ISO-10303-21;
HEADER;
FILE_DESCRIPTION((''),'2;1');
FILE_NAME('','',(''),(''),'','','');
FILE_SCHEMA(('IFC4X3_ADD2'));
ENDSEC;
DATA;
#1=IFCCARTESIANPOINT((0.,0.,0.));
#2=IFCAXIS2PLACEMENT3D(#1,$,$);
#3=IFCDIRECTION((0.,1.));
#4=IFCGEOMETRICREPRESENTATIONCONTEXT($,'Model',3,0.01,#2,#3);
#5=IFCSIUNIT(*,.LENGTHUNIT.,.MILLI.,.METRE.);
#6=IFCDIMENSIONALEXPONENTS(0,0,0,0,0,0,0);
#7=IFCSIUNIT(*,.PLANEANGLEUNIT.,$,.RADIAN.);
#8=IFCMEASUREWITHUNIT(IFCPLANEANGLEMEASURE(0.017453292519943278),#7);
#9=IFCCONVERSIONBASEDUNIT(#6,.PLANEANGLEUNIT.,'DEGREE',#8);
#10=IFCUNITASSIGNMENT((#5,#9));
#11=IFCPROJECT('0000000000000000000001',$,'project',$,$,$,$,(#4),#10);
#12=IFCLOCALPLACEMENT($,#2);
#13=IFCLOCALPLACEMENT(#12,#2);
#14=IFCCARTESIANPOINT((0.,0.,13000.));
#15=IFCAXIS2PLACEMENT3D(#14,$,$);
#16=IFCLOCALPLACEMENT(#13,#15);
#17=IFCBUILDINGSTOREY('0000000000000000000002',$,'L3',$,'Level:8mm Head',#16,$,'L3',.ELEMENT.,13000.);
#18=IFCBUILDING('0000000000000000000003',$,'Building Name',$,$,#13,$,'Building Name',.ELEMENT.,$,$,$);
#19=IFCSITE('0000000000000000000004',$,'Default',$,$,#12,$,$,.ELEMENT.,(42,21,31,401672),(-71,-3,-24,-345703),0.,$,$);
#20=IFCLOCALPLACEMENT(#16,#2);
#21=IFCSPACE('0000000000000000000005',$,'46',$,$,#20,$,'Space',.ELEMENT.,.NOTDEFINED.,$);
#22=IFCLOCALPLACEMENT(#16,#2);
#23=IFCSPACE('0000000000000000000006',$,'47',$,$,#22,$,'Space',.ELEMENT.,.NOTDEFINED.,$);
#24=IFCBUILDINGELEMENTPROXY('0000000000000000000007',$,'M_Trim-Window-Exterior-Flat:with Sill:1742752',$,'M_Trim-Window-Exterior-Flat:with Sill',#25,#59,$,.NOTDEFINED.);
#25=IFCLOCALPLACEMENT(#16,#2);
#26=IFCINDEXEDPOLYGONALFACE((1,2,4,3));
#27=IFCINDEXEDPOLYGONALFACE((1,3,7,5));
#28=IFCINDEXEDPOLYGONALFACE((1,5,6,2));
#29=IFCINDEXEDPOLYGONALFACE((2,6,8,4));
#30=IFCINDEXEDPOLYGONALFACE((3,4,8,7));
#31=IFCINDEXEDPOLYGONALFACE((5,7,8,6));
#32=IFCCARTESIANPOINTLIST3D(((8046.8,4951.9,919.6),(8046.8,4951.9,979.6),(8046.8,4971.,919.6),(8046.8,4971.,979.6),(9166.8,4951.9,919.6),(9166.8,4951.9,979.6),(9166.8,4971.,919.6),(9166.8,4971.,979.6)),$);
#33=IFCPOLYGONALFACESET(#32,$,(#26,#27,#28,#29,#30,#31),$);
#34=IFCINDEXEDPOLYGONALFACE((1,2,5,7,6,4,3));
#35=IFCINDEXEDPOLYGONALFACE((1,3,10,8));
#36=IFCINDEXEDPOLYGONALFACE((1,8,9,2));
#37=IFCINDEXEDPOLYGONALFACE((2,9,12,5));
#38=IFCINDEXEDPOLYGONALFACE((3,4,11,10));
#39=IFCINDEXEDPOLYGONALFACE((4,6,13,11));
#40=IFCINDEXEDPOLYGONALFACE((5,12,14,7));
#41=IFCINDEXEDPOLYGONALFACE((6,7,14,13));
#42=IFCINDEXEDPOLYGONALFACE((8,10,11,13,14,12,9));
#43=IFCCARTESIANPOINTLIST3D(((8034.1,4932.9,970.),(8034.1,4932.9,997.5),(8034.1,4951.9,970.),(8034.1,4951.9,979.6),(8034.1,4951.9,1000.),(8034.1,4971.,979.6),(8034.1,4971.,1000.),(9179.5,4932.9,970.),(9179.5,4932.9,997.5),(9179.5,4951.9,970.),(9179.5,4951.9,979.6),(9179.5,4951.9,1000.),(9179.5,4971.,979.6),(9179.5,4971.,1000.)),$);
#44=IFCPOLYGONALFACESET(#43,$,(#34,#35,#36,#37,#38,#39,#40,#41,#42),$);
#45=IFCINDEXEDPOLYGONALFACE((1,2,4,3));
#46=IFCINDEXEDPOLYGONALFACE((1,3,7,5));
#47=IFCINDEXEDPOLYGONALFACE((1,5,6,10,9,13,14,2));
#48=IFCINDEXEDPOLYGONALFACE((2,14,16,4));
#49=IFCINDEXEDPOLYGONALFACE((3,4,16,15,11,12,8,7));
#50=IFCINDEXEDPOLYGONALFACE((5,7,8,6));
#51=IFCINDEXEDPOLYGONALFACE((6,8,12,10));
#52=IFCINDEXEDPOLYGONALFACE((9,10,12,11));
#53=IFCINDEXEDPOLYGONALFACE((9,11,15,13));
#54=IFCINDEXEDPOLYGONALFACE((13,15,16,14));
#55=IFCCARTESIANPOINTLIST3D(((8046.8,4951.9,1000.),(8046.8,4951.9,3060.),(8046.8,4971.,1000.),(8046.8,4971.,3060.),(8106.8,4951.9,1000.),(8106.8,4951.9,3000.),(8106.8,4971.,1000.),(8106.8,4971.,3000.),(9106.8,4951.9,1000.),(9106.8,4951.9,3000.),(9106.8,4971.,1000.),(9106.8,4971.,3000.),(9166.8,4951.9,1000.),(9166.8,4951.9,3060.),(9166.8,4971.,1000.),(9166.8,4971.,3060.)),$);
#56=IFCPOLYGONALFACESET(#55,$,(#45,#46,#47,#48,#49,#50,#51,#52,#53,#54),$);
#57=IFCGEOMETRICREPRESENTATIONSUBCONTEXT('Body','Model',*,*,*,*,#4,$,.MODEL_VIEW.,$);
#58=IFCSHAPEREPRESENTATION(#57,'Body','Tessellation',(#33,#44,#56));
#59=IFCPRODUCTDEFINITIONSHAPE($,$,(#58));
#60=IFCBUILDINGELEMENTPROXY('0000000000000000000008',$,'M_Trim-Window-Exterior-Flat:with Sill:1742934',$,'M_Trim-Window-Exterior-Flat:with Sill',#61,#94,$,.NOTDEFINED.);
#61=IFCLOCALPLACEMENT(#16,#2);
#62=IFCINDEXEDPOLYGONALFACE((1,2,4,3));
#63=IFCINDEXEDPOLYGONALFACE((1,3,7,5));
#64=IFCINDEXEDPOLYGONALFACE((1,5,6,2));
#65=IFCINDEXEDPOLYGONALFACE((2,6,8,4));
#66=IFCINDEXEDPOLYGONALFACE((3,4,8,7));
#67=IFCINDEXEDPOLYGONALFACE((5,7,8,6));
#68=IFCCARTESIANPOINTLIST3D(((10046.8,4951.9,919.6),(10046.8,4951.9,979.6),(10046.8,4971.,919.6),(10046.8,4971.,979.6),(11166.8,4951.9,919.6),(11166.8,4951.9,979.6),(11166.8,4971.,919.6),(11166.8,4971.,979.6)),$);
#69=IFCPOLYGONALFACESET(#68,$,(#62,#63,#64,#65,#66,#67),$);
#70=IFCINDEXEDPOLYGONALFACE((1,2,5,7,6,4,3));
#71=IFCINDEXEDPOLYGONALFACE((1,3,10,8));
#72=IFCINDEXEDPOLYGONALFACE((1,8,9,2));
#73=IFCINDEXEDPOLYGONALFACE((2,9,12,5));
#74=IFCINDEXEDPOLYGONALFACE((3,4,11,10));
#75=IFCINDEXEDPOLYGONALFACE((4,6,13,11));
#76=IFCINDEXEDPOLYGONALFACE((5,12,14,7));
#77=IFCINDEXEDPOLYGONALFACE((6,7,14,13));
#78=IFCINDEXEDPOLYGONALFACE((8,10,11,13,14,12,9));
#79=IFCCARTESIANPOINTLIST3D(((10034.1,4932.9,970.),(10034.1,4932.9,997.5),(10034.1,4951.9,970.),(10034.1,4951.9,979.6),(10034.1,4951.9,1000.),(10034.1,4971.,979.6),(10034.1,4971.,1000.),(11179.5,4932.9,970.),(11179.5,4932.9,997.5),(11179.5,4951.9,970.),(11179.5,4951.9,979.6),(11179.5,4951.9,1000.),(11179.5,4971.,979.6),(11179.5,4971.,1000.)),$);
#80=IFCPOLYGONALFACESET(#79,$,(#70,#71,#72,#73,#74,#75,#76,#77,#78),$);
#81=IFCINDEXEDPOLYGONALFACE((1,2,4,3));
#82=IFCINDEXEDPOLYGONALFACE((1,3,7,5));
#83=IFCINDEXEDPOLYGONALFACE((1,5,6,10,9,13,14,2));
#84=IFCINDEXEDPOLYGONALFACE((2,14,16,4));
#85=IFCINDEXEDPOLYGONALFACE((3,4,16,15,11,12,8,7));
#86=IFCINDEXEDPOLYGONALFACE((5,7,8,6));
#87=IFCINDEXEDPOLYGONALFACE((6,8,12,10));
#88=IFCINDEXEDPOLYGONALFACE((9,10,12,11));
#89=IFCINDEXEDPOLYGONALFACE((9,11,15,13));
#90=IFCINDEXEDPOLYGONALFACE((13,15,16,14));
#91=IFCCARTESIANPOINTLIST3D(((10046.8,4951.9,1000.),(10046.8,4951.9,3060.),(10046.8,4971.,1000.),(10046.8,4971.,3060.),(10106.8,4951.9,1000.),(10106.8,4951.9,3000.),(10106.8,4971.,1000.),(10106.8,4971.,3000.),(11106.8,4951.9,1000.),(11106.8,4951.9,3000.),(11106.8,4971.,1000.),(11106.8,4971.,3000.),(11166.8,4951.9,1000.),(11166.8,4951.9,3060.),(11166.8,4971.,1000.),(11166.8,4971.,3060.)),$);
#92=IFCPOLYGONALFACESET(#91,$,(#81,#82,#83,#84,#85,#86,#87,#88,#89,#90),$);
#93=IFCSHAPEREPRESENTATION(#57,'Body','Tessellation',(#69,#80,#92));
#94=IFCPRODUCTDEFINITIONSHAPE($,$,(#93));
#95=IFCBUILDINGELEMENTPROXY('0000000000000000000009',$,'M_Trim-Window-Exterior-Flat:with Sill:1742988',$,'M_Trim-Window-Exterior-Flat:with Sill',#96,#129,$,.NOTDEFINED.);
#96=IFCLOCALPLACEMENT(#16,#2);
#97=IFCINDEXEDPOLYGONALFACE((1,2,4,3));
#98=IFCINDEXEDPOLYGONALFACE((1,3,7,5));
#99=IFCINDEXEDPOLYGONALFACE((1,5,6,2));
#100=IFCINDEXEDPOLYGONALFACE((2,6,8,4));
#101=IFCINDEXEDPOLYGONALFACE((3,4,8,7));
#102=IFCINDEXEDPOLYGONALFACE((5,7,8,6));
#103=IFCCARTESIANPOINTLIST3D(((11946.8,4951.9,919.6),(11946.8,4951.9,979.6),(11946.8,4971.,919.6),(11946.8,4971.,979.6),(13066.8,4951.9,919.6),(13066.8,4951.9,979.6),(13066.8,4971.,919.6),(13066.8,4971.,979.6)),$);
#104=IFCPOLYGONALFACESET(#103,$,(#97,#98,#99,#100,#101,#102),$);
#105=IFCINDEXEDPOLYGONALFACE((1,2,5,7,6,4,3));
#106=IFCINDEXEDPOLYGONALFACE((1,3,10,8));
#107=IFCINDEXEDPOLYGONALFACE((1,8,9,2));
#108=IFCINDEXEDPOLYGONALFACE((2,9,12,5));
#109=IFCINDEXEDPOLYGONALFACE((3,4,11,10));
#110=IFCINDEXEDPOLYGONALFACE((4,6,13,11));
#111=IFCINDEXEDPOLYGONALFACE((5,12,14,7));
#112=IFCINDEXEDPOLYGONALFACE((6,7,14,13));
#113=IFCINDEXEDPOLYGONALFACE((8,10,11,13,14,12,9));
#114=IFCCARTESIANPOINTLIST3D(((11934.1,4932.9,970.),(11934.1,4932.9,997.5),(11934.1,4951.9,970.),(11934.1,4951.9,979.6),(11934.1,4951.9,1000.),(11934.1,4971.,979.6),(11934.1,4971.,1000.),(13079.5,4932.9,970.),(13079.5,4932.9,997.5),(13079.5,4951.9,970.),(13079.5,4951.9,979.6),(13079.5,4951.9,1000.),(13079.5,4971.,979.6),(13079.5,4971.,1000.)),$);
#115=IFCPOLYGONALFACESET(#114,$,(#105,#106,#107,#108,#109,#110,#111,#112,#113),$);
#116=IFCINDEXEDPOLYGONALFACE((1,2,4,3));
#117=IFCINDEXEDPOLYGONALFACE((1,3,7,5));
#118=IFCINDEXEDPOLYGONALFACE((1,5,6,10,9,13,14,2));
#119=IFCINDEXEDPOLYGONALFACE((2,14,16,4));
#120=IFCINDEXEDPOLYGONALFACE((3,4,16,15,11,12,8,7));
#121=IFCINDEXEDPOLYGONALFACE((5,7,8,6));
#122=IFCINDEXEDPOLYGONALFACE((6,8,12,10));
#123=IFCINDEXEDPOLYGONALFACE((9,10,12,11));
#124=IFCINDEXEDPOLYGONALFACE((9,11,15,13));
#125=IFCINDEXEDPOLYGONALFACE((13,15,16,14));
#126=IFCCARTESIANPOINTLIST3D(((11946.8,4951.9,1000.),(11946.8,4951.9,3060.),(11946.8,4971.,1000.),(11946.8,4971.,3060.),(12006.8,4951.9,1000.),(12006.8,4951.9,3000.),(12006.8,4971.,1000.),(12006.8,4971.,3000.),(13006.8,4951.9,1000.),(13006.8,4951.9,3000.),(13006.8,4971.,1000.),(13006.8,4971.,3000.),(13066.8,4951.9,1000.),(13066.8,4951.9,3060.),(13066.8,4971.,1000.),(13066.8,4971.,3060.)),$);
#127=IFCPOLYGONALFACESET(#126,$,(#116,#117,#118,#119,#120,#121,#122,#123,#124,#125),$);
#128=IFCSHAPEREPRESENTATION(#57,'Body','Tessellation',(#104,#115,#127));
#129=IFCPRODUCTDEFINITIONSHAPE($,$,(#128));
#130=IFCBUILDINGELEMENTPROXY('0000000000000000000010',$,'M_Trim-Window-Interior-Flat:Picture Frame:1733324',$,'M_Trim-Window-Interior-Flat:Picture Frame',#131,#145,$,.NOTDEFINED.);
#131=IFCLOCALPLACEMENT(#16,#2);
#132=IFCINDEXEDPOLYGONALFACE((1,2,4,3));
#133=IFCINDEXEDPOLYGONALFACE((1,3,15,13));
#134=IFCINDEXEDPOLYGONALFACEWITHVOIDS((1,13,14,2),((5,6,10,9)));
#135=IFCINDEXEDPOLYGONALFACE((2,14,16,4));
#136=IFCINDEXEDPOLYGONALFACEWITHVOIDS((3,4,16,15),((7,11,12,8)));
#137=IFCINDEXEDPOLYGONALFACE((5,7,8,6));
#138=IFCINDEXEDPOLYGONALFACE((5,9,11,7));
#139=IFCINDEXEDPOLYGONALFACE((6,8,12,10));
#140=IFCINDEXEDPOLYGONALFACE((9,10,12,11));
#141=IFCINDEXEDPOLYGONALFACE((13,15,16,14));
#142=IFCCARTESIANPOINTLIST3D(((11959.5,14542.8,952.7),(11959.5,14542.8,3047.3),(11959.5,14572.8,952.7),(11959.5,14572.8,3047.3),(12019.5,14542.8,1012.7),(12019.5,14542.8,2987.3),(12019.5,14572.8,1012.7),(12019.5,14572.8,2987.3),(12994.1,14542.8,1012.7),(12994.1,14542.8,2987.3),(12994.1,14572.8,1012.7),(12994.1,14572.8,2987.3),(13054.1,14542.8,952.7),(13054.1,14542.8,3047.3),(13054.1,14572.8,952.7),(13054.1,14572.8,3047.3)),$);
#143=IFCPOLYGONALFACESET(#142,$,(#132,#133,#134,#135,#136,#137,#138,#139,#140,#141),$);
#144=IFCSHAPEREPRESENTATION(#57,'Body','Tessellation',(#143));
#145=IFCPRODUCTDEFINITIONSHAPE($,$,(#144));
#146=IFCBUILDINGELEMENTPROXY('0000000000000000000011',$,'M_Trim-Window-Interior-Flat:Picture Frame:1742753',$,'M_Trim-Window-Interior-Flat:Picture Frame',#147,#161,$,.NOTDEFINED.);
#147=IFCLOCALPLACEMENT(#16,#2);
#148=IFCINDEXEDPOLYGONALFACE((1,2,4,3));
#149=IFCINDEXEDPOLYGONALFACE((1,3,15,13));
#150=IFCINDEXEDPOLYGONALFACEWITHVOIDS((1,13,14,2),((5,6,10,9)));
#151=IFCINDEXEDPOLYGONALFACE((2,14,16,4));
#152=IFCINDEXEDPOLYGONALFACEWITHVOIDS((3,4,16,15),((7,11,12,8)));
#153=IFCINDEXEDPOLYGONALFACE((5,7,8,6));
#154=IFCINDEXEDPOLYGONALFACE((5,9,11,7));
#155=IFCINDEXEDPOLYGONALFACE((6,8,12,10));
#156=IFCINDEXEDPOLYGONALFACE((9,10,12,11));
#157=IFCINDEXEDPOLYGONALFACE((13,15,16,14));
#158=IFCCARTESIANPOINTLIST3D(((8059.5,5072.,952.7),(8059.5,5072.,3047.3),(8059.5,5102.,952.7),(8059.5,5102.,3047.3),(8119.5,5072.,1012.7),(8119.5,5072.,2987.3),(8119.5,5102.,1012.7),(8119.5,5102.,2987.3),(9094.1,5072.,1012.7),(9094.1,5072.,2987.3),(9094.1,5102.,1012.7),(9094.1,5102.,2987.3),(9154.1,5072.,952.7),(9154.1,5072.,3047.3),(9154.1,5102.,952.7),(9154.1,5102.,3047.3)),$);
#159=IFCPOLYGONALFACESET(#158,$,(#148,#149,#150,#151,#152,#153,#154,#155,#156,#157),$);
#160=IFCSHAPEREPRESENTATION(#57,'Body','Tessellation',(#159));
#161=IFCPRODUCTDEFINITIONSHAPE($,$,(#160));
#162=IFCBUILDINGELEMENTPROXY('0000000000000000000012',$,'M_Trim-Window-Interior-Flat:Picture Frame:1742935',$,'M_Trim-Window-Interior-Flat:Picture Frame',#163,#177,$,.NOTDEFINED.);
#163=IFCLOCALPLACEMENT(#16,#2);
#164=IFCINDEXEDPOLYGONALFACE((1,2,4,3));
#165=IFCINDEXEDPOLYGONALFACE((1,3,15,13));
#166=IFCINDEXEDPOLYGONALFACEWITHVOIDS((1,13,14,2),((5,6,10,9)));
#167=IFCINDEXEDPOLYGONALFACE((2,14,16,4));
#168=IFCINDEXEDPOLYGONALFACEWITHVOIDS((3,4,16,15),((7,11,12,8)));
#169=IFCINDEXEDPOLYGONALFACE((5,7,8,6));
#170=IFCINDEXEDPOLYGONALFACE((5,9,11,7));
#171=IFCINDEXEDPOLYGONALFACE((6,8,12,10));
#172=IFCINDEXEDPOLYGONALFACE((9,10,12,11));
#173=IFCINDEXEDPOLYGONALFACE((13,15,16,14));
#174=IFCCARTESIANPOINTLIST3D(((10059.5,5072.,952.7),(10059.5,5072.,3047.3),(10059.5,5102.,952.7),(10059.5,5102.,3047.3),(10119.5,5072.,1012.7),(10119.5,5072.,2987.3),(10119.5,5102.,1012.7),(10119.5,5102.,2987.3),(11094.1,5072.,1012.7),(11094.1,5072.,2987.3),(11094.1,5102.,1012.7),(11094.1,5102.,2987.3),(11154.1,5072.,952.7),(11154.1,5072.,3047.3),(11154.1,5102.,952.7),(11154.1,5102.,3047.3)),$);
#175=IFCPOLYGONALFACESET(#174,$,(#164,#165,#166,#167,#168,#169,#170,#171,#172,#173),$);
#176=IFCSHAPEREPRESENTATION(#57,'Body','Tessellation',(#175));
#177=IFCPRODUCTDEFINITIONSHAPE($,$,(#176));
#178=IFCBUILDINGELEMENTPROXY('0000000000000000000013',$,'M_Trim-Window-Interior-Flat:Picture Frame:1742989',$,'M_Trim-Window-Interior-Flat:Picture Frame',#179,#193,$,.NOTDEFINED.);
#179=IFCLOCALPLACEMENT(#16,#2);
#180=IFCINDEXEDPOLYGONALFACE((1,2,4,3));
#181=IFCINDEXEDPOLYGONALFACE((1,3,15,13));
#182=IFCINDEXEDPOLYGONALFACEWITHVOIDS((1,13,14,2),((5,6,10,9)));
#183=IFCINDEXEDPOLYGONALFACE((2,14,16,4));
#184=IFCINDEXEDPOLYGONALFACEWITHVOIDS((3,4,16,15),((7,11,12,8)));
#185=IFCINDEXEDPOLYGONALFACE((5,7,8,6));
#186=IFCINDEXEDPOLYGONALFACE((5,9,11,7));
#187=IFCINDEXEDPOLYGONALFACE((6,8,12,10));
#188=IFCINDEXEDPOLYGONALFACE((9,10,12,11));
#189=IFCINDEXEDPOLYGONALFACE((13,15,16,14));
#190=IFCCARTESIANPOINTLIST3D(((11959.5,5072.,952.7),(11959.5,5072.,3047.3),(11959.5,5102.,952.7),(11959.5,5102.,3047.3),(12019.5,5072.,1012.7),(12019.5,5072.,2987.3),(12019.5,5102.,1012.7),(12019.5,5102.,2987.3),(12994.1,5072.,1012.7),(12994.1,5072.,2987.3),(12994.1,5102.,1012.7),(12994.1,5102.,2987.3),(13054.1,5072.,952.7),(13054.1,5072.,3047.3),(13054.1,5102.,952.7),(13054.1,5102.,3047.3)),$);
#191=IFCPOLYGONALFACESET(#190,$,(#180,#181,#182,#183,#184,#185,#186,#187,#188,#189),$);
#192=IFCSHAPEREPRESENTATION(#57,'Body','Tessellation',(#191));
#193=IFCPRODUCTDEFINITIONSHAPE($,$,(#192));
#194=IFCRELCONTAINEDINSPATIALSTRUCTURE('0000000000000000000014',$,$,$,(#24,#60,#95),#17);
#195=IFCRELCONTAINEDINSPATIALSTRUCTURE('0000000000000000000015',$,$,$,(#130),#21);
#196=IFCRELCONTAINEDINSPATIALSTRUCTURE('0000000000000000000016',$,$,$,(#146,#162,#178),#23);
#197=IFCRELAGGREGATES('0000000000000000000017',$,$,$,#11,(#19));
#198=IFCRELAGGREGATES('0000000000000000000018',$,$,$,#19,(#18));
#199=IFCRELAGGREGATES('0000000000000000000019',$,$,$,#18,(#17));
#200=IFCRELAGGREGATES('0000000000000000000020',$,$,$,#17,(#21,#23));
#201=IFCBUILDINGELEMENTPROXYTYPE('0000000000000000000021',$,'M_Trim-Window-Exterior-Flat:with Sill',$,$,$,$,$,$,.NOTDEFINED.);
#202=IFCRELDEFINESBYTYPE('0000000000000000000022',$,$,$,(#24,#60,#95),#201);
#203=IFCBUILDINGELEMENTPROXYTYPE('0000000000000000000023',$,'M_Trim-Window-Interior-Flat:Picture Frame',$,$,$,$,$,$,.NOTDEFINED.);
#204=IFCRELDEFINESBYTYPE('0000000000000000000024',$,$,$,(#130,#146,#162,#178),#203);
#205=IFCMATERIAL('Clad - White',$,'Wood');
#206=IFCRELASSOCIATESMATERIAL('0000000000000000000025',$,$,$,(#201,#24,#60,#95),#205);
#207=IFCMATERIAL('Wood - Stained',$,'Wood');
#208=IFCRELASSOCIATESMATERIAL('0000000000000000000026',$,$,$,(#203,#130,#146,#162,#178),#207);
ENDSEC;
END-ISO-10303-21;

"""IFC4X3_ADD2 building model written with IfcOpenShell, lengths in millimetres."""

from ifc_helpers import new_model, entity, si_unit, converted_unit, direction, frame, frame_2d, origin, place, context, subcontext, project, spatial, polyline, rectangle, outline, extrude, source, transform, mapped, material, type_object, type_shapes, element, save


model = new_model("IFC4X3_ADD2")

# Units and contexts
model_context = context("Model", 3, precision=0.01, world=origin(), true_north=direction((0.0, 1.0)))
body_context = subcontext(model_context, "Body", "Model", "MODEL_VIEW")
ifc_project = project(units=[si_unit("LENGTHUNIT", "METRE", prefix="MILLI"), converted_unit("PLANEANGLEUNIT", "DEGREE", entity("IfcPlaneAngleMeasure", 0.017453292519943278), si_unit("PLANEANGLEUNIT", "RADIAN"), dimensions=[0, 0, 0, 0, 0, 0, 0])], contexts=[model_context])

# Site, building, storey
site_placement = place(None, origin())
site = spatial("IfcSite", under=ifc_project, at=site_placement, Name="Default", CompositionType="ELEMENT", RefLatitude=(42, 21, 31, 401672), RefLongitude=(-71, -3, -24, -345703), RefElevation=0.0)
building_placement = place(site_placement, origin())
building = spatial("IfcBuilding", under=site, at=building_placement, Name="Building Name", LongName="Building Name", CompositionType="ELEMENT")
storey_placement = place(building_placement, frame((0.0, 0.0, 13000.0)))
storey = spatial("IfcBuildingStorey", under=building, at=storey_placement, Name="L3", ObjectType="Level:8mm Head", LongName="L3", CompositionType="ELEMENT", Elevation=13000.0)

# Building element proxies
ifc_material_1 = material(Name="Clad - White", Category="Wood")
ifc_material_2 = material(Name="Wood - Stained", Category="Wood")
building_element_proxy_type_1 = type_object("IfcBuildingElementProxyType", Name="M_Trim-Window-Exterior-Flat:with Sill", PredefinedType="NOTDEFINED", material=ifc_material_1)
shared_shape_1 = source(origin(), body_context, "Body", "SweptSolid", [
    extrude(rectangle(XDim=1120.0, YDim=60.0, at=frame_2d((0.0, 0.0), x_axis=(1.0, 0.0))), frame((0.0, -2050.4, 0.0), z_axis=(0.0, 0.0, 1.0), x_axis=(-1.0, 0.0, 0.0)), (0.0, 0.0, 1.0), 19.0),
    extrude(outline(polyline([(-19.0, -15.2), (0.0, -15.2), (0.0, -5.7), (19.0, -5.7), (19.0, 14.8), (0.0, 14.8), (-19.0, 12.3), (-19.0, -15.2)])), frame((-572.7, -2014.8, 19.0), z_axis=(1.0, 0.0, 0.0), x_axis=(0.0, 0.0, -1.0)), (0.0, 0.0, 1.0), 1145.4),
    extrude(outline(polyline([(-1045.0, -560.0), (1015.0, -560.0), (1015.0, -500.0), (-985.0, -500.0), (-985.0, 500.0), (1015.0, 500.0), (1015.0, 560.0), (-1045.0, 560.0), (-1045.0, -560.0)])), frame((0.0, -985.0, 0.0), z_axis=(0.0, 0.0, 1.0), x_axis=(0.0, -1.0, 0.0)), (0.0, 0.0, 1.0), 19.0),
])
type_shapes(building_element_proxy_type_1, [shared_shape_1])
for number, where, z_axis, x_axis, name in (
    (1, (8606.8, 4971.0, 3000.0), (0.0, -1.0, 0.0), (1.0, 0.0, 0.0), "M_Trim-Window-Exterior-Flat:with Sill:1742752"),
    (2, (10606.8, 4971.0, 3000.0), (0.0, -1.0, 0.0), (1.0, 0.0, 0.0), "M_Trim-Window-Exterior-Flat:with Sill:1742934"),
    (3, (12506.8, 4971.0, 3000.0), (0.0, -1.0, 0.0), (1.0, 0.0, 0.0), "M_Trim-Window-Exterior-Flat:with Sill:1742988"),
):
    element("IfcBuildingElementProxy", number, at=place(storey_placement, frame(where, z_axis=z_axis, x_axis=x_axis)), inside=storey, type_object=building_element_proxy_type_1, material=ifc_material_1, Name=name, ObjectType="M_Trim-Window-Exterior-Flat:with Sill", PredefinedType="NOTDEFINED", context=body_context, shape_type="MappedRepresentation", body=[
        mapped(shared_shape_1, transform((0.0, 0.0, 0.0), scale=1.0)),
    ])

# Shared definitions
space_1_placement = place(storey_placement, origin())
space_1 = spatial("IfcSpace", under=storey, at=space_1_placement, Name="46", LongName="Space", CompositionType="ELEMENT", PredefinedType="NOTDEFINED")

# Building element proxy
building_element_proxy_type_2 = type_object("IfcBuildingElementProxyType", Name="M_Trim-Window-Interior-Flat:Picture Frame", PredefinedType="NOTDEFINED", material=ifc_material_2)
shared_shape_2 = source(origin(), body_context, "Body", "SweptSolid", [
    extrude(outline(polyline([(-547.3, -1047.3), (547.3, -1047.3), (547.3, 1047.3), (-547.3, 1047.3), (-547.3, -1047.3)]), holes=[polyline([(-487.3, -987.3), (-487.3, 987.3), (487.3, 987.3), (487.3, -987.3), (-487.3, -987.3)])]), frame((0.0, -1000.0, 0.0), z_axis=(0.0, 0.0, 1.0), x_axis=(-1.0, 0.0, 0.0)), (0.0, 0.0, 1.0), 30.0),
])
type_shapes(building_element_proxy_type_2, [shared_shape_2])
proxy_1_placement = place(space_1_placement, frame((12506.8, 14572.8, 3000.0), z_axis=(0.0, -1.0, 0.0), x_axis=(1.0, 0.0, 0.0)))
element("IfcBuildingElementProxy", 4, at=proxy_1_placement, inside=space_1, type_object=building_element_proxy_type_2, material=ifc_material_2, Name="M_Trim-Window-Interior-Flat:Picture Frame:1733324", ObjectType="M_Trim-Window-Interior-Flat:Picture Frame", PredefinedType="NOTDEFINED", context=body_context, shape_type="MappedRepresentation", body=[
    mapped(shared_shape_2, transform((0.0, 0.0, 0.0), scale=1.0)),
])

# Shared definitions
space_2_placement = place(storey_placement, origin())
space_2 = spatial("IfcSpace", under=storey, at=space_2_placement, Name="47", LongName="Space", CompositionType="ELEMENT", PredefinedType="NOTDEFINED")

# Building element proxies
for number, where, z_axis, x_axis, name in (
    (5, (8606.8, 5072.0, 3000.0), (0.0, 1.0, 0.0), (-1.0, 0.0, 0.0), "M_Trim-Window-Interior-Flat:Picture Frame:1742753"),
    (6, (10606.8, 5072.0, 3000.0), (0.0, 1.0, 0.0), (-1.0, 0.0, 0.0), "M_Trim-Window-Interior-Flat:Picture Frame:1742935"),
    (7, (12506.8, 5072.0, 3000.0), (0.0, 1.0, 0.0), (-1.0, 0.0, 0.0), "M_Trim-Window-Interior-Flat:Picture Frame:1742989"),
):
    element("IfcBuildingElementProxy", number, at=place(space_2_placement, frame(where, z_axis=z_axis, x_axis=x_axis)), inside=space_2, type_object=building_element_proxy_type_2, material=ifc_material_2, Name=name, ObjectType="M_Trim-Window-Interior-Flat:Picture Frame", PredefinedType="NOTDEFINED", context=body_context, shape_type="MappedRepresentation", body=[
        mapped(shared_shape_2, transform((0.0, 0.0, 0.0), scale=1.0)),
    ])

save(model, "model.ifc")
